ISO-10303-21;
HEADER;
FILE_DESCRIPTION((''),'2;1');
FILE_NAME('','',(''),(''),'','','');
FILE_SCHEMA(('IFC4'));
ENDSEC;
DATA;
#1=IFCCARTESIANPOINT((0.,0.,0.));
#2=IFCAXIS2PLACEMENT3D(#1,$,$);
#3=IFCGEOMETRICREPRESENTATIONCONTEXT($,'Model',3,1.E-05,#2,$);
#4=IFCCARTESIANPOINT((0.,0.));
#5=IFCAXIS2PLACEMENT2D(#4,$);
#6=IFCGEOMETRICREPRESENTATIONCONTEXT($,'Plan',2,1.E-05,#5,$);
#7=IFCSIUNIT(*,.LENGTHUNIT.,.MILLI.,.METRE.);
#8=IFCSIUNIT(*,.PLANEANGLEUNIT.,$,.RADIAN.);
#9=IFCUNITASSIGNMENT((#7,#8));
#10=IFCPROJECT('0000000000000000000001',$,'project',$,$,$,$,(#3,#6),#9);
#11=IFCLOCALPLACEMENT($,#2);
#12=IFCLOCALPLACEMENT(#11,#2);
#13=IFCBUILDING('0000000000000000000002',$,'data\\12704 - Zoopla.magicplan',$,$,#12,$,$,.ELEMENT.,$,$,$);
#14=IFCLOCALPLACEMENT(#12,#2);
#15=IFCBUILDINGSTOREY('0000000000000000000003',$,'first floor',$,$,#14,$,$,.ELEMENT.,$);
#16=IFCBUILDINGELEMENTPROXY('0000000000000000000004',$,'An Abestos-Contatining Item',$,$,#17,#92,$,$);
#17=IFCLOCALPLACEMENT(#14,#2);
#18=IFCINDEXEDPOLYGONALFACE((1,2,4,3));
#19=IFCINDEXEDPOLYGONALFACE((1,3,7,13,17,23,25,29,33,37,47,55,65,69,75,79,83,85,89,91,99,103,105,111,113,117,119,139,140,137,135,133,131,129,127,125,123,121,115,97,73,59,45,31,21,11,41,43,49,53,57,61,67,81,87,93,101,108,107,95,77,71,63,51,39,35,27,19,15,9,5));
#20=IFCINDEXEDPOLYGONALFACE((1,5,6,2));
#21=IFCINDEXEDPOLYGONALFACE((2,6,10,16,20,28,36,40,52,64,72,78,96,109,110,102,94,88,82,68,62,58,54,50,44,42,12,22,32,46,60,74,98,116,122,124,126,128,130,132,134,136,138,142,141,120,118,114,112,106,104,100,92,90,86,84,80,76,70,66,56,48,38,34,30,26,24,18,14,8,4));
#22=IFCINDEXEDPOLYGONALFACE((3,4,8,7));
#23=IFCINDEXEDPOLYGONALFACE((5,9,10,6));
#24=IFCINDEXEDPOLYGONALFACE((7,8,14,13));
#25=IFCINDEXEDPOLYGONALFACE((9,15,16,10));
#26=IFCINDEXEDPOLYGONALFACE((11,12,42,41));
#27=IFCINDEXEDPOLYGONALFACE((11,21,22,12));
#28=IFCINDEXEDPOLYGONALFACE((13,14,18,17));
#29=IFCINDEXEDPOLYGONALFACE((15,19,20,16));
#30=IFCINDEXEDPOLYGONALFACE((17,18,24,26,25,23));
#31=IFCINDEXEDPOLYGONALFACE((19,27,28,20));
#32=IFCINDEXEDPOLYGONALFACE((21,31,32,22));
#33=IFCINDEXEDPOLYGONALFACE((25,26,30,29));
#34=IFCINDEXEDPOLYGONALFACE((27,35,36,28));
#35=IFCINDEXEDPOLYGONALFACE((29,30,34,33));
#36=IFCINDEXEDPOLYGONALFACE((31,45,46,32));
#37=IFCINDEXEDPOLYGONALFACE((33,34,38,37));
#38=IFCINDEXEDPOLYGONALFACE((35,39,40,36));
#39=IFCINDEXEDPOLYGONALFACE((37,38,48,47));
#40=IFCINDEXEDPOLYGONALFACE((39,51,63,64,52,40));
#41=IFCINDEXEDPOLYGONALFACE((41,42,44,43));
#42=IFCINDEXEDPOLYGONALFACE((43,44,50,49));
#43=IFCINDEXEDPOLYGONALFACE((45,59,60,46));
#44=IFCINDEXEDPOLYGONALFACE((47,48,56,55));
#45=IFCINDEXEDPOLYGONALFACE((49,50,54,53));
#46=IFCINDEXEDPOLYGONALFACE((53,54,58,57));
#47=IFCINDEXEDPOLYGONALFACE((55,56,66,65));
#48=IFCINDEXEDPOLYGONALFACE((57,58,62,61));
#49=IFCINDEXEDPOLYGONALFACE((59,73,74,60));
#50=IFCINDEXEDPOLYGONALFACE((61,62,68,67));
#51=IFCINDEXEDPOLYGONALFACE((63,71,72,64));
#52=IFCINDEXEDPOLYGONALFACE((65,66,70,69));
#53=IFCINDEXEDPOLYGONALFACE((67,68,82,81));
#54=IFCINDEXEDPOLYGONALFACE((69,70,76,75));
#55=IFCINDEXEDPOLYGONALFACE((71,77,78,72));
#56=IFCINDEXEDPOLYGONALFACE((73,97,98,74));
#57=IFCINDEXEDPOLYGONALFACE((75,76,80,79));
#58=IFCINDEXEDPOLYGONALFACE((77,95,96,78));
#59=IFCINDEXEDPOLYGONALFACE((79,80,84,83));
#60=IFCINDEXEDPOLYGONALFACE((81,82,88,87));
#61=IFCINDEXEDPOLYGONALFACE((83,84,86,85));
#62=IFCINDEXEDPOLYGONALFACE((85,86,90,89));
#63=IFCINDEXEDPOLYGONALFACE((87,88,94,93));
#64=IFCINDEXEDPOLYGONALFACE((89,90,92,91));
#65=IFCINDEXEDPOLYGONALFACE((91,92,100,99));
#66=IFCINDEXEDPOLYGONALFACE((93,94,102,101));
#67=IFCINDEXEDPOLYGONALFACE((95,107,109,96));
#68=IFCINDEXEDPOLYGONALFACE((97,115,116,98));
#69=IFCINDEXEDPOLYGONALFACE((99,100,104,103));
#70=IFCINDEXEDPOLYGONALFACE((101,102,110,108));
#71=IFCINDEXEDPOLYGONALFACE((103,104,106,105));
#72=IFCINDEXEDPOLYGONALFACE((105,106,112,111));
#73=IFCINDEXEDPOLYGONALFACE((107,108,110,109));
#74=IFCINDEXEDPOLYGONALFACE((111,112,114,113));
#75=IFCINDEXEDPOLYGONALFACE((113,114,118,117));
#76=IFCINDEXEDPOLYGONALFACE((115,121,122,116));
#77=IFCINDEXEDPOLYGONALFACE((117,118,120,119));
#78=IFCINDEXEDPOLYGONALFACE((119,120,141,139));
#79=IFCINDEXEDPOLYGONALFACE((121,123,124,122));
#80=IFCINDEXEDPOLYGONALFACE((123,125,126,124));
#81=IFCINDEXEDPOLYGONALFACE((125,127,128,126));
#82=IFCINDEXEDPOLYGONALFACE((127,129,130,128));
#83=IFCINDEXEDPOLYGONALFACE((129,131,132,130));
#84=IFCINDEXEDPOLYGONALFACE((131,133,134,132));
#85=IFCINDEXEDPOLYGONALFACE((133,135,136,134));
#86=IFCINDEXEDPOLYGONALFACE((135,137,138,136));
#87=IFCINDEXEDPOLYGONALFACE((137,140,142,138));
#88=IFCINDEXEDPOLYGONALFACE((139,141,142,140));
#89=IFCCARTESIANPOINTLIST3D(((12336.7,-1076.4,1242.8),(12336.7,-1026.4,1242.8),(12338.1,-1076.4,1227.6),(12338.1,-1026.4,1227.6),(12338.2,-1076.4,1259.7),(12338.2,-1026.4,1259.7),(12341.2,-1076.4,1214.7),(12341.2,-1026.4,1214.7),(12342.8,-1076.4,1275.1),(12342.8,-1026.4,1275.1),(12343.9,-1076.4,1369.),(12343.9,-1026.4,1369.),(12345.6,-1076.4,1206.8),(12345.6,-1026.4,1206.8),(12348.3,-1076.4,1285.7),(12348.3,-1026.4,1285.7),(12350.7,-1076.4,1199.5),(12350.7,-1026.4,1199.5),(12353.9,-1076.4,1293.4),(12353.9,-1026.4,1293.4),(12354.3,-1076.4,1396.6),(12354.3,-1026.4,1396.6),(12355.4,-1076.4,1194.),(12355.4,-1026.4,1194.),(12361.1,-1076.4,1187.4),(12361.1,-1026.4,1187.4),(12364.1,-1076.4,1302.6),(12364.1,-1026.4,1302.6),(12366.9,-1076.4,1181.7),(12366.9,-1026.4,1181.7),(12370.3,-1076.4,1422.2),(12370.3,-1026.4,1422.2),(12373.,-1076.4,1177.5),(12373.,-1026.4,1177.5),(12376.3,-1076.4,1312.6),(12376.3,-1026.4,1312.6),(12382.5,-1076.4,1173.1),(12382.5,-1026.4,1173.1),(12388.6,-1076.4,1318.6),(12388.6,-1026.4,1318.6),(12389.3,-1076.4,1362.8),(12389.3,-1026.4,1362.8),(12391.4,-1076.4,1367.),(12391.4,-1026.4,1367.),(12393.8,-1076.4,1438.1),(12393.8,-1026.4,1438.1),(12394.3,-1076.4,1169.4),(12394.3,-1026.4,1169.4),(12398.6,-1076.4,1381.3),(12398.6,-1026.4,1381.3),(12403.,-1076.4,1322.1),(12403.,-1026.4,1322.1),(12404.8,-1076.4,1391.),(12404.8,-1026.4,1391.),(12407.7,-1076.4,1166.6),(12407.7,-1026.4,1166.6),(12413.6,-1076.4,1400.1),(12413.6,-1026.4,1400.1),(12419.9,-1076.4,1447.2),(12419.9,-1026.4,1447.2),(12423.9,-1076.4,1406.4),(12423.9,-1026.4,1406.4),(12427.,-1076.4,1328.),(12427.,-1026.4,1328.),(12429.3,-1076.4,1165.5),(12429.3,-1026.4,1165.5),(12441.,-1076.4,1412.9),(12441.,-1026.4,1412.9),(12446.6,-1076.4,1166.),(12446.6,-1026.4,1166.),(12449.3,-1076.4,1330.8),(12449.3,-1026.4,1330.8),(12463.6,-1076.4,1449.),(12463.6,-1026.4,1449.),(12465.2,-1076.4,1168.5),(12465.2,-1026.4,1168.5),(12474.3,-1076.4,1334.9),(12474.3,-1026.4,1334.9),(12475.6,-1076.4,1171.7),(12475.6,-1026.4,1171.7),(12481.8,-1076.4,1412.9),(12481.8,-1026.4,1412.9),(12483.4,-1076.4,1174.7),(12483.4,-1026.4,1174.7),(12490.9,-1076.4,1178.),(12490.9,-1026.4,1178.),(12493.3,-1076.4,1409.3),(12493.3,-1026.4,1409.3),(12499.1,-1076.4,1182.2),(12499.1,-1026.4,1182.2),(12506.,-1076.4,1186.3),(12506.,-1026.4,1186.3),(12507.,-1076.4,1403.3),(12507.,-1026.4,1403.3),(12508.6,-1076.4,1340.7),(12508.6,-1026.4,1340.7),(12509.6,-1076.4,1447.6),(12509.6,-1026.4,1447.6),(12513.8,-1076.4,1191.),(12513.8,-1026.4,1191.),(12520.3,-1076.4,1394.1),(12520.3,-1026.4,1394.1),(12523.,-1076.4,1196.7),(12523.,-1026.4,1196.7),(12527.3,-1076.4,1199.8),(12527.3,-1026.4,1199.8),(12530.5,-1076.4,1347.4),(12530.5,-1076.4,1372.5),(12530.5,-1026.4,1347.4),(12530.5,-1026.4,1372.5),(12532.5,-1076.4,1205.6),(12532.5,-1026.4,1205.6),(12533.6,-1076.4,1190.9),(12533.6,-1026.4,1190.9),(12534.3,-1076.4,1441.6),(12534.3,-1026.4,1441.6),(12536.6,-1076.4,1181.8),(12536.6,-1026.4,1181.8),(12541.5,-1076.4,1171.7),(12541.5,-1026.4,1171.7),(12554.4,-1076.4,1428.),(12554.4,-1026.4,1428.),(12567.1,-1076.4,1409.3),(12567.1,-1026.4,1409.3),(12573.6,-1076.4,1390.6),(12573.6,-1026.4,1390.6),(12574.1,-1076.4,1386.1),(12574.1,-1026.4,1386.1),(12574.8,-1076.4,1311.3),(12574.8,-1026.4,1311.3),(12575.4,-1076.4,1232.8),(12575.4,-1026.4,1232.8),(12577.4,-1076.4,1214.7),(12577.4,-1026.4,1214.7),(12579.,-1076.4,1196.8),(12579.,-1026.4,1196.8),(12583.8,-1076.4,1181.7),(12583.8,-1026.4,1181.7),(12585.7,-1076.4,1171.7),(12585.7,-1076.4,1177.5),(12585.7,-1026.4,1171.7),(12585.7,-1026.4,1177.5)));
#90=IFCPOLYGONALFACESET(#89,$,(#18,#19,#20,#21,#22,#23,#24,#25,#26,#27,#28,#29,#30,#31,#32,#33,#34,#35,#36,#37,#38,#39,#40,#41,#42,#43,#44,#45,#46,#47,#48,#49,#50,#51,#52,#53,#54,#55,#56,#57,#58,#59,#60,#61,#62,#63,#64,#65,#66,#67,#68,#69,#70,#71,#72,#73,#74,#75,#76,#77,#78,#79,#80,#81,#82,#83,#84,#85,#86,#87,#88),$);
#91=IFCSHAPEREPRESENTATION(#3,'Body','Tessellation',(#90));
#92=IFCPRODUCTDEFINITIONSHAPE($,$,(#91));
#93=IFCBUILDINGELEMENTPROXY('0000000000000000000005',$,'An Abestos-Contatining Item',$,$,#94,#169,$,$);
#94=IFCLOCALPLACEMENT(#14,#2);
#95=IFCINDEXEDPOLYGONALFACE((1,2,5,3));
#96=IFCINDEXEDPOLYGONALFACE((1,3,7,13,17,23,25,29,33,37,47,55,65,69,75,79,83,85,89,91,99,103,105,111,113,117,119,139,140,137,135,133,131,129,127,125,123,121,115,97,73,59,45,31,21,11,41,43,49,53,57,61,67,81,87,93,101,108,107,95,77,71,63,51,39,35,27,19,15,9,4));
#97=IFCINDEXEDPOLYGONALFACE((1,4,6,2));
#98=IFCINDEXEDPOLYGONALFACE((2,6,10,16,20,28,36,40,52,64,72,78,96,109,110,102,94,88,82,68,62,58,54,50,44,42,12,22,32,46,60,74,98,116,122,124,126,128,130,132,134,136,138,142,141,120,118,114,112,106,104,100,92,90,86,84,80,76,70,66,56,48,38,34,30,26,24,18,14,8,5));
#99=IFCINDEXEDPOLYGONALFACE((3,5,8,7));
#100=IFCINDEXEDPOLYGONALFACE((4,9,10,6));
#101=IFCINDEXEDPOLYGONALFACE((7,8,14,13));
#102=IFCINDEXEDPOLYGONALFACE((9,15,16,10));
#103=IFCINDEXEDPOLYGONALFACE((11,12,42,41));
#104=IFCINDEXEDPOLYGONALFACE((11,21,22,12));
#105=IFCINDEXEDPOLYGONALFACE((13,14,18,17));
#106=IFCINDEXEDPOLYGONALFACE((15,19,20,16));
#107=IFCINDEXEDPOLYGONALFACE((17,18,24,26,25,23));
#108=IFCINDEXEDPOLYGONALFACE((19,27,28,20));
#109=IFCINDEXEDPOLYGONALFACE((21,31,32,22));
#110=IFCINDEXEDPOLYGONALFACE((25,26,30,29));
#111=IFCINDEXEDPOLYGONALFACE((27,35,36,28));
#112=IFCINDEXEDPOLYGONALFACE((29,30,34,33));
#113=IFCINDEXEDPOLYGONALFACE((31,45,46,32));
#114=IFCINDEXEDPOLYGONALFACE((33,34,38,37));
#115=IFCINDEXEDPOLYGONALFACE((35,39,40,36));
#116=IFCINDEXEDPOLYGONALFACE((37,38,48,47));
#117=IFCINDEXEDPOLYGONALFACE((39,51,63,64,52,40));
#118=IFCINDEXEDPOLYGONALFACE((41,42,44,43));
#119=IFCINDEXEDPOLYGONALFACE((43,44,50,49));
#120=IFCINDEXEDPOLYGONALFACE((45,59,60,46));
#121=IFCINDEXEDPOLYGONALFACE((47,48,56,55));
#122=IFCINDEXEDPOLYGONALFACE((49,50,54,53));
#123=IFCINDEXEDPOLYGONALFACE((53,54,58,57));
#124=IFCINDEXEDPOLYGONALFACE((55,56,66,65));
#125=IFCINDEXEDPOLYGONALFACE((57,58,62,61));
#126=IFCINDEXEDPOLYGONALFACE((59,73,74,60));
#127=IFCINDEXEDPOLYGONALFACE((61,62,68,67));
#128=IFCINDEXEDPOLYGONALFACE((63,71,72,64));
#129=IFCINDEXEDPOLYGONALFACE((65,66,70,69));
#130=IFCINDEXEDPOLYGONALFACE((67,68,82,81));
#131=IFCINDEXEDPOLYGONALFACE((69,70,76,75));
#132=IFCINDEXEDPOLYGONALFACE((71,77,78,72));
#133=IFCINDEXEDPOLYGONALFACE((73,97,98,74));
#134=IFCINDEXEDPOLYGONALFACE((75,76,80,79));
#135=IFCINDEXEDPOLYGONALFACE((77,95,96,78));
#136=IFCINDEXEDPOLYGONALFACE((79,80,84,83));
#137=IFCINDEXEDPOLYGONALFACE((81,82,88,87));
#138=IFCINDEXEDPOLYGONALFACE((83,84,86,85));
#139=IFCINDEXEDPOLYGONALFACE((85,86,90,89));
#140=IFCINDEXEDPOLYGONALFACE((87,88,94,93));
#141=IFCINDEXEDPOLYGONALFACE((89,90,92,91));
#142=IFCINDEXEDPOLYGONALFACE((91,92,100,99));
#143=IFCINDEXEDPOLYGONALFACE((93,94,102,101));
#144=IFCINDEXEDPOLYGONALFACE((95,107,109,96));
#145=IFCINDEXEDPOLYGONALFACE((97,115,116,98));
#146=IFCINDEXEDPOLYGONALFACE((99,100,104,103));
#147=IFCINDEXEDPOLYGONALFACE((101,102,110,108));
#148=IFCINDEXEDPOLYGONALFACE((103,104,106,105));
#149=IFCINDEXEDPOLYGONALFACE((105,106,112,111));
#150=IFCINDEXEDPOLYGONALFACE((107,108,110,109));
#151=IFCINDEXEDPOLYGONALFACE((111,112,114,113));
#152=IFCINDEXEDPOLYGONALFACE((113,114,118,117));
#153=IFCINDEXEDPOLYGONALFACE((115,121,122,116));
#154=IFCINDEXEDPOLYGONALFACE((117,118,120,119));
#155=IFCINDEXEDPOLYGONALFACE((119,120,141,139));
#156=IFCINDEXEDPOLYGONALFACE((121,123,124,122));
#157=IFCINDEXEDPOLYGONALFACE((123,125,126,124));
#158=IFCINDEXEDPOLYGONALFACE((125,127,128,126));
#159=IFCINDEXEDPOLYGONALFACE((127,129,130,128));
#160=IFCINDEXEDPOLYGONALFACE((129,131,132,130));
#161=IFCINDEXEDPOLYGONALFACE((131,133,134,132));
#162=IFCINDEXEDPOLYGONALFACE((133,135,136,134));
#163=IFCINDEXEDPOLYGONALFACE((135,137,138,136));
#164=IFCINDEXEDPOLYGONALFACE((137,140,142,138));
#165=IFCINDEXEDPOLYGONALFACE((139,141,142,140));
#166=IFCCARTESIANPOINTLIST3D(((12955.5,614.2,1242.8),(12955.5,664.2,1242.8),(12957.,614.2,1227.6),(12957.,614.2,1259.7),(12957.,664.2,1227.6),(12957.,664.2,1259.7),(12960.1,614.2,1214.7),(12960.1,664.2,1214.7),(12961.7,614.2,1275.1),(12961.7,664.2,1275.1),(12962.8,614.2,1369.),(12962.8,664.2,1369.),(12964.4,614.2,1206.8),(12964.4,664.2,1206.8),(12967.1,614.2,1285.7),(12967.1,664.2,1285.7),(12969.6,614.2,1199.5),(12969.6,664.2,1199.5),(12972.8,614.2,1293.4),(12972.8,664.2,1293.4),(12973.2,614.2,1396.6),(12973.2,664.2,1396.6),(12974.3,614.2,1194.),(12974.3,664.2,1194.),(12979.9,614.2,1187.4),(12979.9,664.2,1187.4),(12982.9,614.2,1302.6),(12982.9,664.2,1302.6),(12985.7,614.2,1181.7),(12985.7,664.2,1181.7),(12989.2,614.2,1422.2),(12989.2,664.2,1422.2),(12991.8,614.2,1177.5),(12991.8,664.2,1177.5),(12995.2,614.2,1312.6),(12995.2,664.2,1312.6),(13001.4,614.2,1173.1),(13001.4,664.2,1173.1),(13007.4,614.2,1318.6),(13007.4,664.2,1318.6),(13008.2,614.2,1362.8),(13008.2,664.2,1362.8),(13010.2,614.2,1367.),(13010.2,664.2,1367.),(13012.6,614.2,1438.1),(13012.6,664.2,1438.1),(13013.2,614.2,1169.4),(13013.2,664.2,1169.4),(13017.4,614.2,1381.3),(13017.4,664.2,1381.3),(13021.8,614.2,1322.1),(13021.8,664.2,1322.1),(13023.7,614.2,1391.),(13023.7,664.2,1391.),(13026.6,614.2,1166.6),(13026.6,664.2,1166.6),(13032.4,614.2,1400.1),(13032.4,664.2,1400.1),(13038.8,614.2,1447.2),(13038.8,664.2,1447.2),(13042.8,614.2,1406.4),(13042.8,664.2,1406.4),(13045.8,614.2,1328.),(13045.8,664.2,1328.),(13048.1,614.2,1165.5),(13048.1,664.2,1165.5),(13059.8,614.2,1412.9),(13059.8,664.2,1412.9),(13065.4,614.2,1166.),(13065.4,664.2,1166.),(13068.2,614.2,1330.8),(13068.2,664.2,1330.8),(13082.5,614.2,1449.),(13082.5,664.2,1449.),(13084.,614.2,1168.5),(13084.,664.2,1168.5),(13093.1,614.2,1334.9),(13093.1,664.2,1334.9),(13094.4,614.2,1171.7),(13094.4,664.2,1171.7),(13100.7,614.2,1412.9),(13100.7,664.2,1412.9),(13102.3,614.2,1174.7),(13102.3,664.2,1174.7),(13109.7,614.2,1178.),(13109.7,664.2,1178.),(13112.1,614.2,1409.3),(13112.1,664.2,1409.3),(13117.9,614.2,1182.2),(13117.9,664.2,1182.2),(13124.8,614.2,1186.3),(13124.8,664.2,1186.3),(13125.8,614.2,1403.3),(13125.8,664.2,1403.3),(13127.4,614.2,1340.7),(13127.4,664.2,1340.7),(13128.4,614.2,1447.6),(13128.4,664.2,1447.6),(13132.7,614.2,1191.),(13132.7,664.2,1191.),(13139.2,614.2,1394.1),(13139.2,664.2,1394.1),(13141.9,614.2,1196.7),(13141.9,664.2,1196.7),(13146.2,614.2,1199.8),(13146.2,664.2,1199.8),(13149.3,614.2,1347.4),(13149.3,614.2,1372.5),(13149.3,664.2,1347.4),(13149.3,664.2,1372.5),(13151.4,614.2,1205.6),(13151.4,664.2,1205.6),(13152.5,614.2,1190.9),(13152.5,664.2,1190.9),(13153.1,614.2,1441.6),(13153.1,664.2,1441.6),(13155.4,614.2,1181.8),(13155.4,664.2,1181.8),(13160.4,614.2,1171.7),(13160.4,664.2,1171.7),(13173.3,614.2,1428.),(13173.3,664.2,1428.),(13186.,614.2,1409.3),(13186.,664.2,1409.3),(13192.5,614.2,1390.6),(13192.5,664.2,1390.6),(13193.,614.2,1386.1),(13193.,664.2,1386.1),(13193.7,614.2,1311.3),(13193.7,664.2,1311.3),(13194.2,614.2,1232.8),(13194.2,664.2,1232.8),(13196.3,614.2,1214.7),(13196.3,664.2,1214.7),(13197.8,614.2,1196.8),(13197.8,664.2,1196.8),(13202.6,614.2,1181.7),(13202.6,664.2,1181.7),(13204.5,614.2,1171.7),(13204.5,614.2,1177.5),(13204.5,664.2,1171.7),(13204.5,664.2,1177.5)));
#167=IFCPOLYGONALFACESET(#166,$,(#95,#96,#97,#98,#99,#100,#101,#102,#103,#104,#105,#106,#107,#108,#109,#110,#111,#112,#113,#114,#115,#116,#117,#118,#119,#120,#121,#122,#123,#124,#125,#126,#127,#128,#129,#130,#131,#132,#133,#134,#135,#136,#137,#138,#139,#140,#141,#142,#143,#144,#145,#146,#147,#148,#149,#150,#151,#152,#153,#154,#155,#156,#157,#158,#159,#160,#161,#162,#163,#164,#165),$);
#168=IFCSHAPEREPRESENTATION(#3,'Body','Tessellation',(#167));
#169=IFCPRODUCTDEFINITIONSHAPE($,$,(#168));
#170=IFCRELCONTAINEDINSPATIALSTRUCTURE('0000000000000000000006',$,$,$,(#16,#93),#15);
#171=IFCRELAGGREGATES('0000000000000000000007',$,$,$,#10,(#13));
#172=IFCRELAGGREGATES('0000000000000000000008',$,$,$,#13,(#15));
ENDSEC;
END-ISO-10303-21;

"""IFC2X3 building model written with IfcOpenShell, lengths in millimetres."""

from ifc_helpers import new_model, si_unit, frame, origin, origin_2d, place, context, project, spatial, polyline, outline, extrude, element, save


model = new_model("IFC2X3")

# Units and contexts
model_context = context("Model", 3, precision=1e-05, world=origin())
plan_context = context("Plan", 2, precision=1e-05, world=origin_2d())
ifc_project = project(units=[si_unit("LENGTHUNIT", "METRE", prefix="MILLI"), si_unit("PLANEANGLEUNIT", "RADIAN")], contexts=[model_context, plan_context])

# Building, storey
placement_1 = place(None, origin())
building_placement = place(placement_1, origin())
building = spatial("IfcBuilding", under=ifc_project, at=building_placement, Name="data\\12704 - Zoopla.magicplan", CompositionType="ELEMENT")
storey_placement = place(building_placement, origin())
storey = spatial("IfcBuildingStorey", under=building, at=storey_placement, Name="first floor", CompositionType="ELEMENT")

# Building element proxies
placement_2 = place(None, frame((12448.2, -975.8, 0.0)))
proxy_1_placement = place(placement_2, frame((-112.5, -50.6, 1165.0)))
element("IfcBuildingElementProxy", 1, at=proxy_1_placement, inside=storey, Name="An Abestos-Contatining Item", context=model_context, shape_type="SurfaceModel", body=[
    extrude(outline(polyline([(239.2, 0.0, 146.3), (239.7, 0.0, 67.8), (241.8, 0.0, 49.7), (243.3, 0.0, 31.9), (248.1, 0.0, 16.7), (250.0, 0.0, 12.5), (250.0, 0.0, 6.7), (205.8, 0.0, 6.7), (200.9, 0.0, 16.8), (197.9, 0.0, 25.9), (196.9, 0.0, 40.6), (191.6, 0.0, 34.8), (187.3, 0.0, 31.7), (178.2, 0.0, 26.0), (170.3, 0.0, 21.3), (163.4, 0.0, 17.2), (155.2, 0.0, 13.0), (147.8, 0.0, 9.7), (139.9, 0.0, 6.7), (129.5, 0.0, 3.5), (110.9, 0.0, 1.0), (93.6, 0.0, 0.5), (72.1, 0.0, 1.6), (58.6, 0.0, 4.4), (46.9, 0.0, 8.1), (37.3, 0.0, 12.5), (31.2, 0.0, 16.7), (25.4, 0.0, 22.4), (19.8, 0.0, 29.0), (15.1, 0.0, 34.5), (9.9, 0.0, 41.9), (5.5, 0.0, 49.7), (2.5, 0.0, 62.6), (1.0, 0.0, 77.8), (2.5, 0.0, 94.7), (7.2, 0.0, 110.1), (12.6, 0.0, 120.7), (18.2, 0.0, 128.4), (28.4, 0.0, 137.6), (40.7, 0.0, 147.6), (52.9, 0.0, 153.6), (67.3, 0.0, 157.1), (91.3, 0.0, 163.0), (113.7, 0.0, 165.8), (138.6, 0.0, 169.9), (172.9, 0.0, 175.7), (194.8, 0.0, 182.4), (194.8, 0.0, 207.5), (184.7, 0.0, 229.1), (171.3, 0.0, 238.3), (157.6, 0.0, 244.3), (146.2, 0.0, 247.9), (105.3, 0.0, 247.9), (88.3, 0.0, 241.4), (77.9, 0.0, 235.1), (69.1, 0.0, 226.0), (62.9, 0.0, 216.3), (55.7, 0.0, 202.0), (53.6, 0.0, 197.8), (8.2, 0.0, 204.0), (18.7, 0.0, 231.7), (34.6, 0.0, 257.2), (58.1, 0.0, 273.1), (84.2, 0.0, 282.2), (128.0, 0.0, 284.0), (173.9, 0.0, 282.6), (198.6, 0.0, 276.6), (218.8, 0.0, 263.1), (231.4, 0.0, 244.3), (238.0, 0.0, 225.6), (238.5, 0.0, 221.1)]), holes=[polyline([(193.0, 0.0, 144.2), (193.0, 0.0, 117.7), (190.5, 0.0, 97.8), (183.8, 0.0, 80.4), (174.2, 0.0, 64.5), (165.3, 0.0, 54.4), (152.5, 0.0, 47.3), (138.0, 0.0, 41.5), (124.6, 0.0, 37.8), (85.5, 0.0, 37.8), (75.0, 0.0, 41.4), (65.8, 0.0, 47.1), (57.8, 0.0, 55.4), (52.1, 0.0, 66.4), (49.5, 0.0, 74.4), (49.5, 0.0, 88.6), (55.3, 0.0, 100.7), (65.3, 0.0, 109.9), (81.0, 0.0, 119.8), (101.0, 0.0, 125.3), (119.9, 0.0, 128.5), (146.8, 0.0, 131.5), (165.0, 0.0, 134.9), (179.8, 0.0, 140.1), (193.0, 0.0, 144.2)])], kind="CURVE"), origin(), (0.0, -1.0, 0.0), 50.0),
])
placement_3 = place(None, frame((12448.2, -975.8, 0.0)))
proxy_2_placement = place(placement_3, frame((506.3, 1640.0, 1165.0)))
element("IfcBuildingElementProxy", 2, at=proxy_2_placement, inside=storey, Name="An Abestos-Contatining Item", context=model_context, shape_type="SurfaceModel", body=[
    extrude(outline(polyline([(239.2, 0.0, 146.3), (239.7, 0.0, 67.8), (241.8, 0.0, 49.7), (243.3, 0.0, 31.9), (248.1, 0.0, 16.7), (250.0, 0.0, 12.5), (250.0, 0.0, 6.7), (205.8, 0.0, 6.7), (200.9, 0.0, 16.8), (197.9, 0.0, 25.9), (196.9, 0.0, 40.6), (191.6, 0.0, 34.8), (187.3, 0.0, 31.7), (178.2, 0.0, 26.0), (170.3, 0.0, 21.3), (163.4, 0.0, 17.2), (155.2, 0.0, 13.0), (147.8, 0.0, 9.7), (139.9, 0.0, 6.7), (129.5, 0.0, 3.5), (110.9, 0.0, 1.0), (93.6, 0.0, 0.5), (72.1, 0.0, 1.6), (58.6, 0.0, 4.4), (46.9, 0.0, 8.1), (37.3, 0.0, 12.5), (31.2, 0.0, 16.7), (25.4, 0.0, 22.4), (19.8, 0.0, 29.0), (15.1, 0.0, 34.5), (9.9, 0.0, 41.9), (5.5, 0.0, 49.7), (2.5, 0.0, 62.6), (1.0, 0.0, 77.8), (2.5, 0.0, 94.7), (7.2, 0.0, 110.1), (12.6, 0.0, 120.7), (18.2, 0.0, 128.4), (28.4, 0.0, 137.6), (40.7, 0.0, 147.6), (52.9, 0.0, 153.6), (67.3, 0.0, 157.1), (91.3, 0.0, 163.0), (113.7, 0.0, 165.8), (138.6, 0.0, 169.9), (172.9, 0.0, 175.7), (194.8, 0.0, 182.4), (194.8, 0.0, 207.5), (184.7, 0.0, 229.1), (171.3, 0.0, 238.3), (157.6, 0.0, 244.3), (146.2, 0.0, 247.9), (105.3, 0.0, 247.9), (88.3, 0.0, 241.4), (77.9, 0.0, 235.1), (69.1, 0.0, 226.0), (62.9, 0.0, 216.3), (55.7, 0.0, 202.0), (53.6, 0.0, 197.8), (8.2, 0.0, 204.0), (18.7, 0.0, 231.7), (34.6, 0.0, 257.2), (58.1, 0.0, 273.1), (84.2, 0.0, 282.2), (128.0, 0.0, 284.0), (173.9, 0.0, 282.6), (198.6, 0.0, 276.6), (218.8, 0.0, 263.1), (231.4, 0.0, 244.3), (238.0, 0.0, 225.6), (238.5, 0.0, 221.1)]), holes=[polyline([(193.0, 0.0, 144.2), (193.0, 0.0, 117.7), (190.5, 0.0, 97.8), (183.8, 0.0, 80.4), (174.2, 0.0, 64.5), (165.3, 0.0, 54.4), (152.5, 0.0, 47.3), (138.0, 0.0, 41.5), (124.6, 0.0, 37.8), (85.5, 0.0, 37.8), (75.0, 0.0, 41.4), (65.8, 0.0, 47.1), (57.8, 0.0, 55.4), (52.1, 0.0, 66.4), (49.5, 0.0, 74.4), (49.5, 0.0, 88.6), (55.3, 0.0, 100.7), (65.3, 0.0, 109.9), (81.0, 0.0, 119.8), (101.0, 0.0, 125.3), (119.9, 0.0, 128.5), (146.8, 0.0, 131.5), (165.0, 0.0, 134.9), (179.8, 0.0, 140.1), (193.0, 0.0, 144.2)])], kind="CURVE"), origin(), (0.0, -1.0, 0.0), 50.0),
])

save(model, "model.ifc")
